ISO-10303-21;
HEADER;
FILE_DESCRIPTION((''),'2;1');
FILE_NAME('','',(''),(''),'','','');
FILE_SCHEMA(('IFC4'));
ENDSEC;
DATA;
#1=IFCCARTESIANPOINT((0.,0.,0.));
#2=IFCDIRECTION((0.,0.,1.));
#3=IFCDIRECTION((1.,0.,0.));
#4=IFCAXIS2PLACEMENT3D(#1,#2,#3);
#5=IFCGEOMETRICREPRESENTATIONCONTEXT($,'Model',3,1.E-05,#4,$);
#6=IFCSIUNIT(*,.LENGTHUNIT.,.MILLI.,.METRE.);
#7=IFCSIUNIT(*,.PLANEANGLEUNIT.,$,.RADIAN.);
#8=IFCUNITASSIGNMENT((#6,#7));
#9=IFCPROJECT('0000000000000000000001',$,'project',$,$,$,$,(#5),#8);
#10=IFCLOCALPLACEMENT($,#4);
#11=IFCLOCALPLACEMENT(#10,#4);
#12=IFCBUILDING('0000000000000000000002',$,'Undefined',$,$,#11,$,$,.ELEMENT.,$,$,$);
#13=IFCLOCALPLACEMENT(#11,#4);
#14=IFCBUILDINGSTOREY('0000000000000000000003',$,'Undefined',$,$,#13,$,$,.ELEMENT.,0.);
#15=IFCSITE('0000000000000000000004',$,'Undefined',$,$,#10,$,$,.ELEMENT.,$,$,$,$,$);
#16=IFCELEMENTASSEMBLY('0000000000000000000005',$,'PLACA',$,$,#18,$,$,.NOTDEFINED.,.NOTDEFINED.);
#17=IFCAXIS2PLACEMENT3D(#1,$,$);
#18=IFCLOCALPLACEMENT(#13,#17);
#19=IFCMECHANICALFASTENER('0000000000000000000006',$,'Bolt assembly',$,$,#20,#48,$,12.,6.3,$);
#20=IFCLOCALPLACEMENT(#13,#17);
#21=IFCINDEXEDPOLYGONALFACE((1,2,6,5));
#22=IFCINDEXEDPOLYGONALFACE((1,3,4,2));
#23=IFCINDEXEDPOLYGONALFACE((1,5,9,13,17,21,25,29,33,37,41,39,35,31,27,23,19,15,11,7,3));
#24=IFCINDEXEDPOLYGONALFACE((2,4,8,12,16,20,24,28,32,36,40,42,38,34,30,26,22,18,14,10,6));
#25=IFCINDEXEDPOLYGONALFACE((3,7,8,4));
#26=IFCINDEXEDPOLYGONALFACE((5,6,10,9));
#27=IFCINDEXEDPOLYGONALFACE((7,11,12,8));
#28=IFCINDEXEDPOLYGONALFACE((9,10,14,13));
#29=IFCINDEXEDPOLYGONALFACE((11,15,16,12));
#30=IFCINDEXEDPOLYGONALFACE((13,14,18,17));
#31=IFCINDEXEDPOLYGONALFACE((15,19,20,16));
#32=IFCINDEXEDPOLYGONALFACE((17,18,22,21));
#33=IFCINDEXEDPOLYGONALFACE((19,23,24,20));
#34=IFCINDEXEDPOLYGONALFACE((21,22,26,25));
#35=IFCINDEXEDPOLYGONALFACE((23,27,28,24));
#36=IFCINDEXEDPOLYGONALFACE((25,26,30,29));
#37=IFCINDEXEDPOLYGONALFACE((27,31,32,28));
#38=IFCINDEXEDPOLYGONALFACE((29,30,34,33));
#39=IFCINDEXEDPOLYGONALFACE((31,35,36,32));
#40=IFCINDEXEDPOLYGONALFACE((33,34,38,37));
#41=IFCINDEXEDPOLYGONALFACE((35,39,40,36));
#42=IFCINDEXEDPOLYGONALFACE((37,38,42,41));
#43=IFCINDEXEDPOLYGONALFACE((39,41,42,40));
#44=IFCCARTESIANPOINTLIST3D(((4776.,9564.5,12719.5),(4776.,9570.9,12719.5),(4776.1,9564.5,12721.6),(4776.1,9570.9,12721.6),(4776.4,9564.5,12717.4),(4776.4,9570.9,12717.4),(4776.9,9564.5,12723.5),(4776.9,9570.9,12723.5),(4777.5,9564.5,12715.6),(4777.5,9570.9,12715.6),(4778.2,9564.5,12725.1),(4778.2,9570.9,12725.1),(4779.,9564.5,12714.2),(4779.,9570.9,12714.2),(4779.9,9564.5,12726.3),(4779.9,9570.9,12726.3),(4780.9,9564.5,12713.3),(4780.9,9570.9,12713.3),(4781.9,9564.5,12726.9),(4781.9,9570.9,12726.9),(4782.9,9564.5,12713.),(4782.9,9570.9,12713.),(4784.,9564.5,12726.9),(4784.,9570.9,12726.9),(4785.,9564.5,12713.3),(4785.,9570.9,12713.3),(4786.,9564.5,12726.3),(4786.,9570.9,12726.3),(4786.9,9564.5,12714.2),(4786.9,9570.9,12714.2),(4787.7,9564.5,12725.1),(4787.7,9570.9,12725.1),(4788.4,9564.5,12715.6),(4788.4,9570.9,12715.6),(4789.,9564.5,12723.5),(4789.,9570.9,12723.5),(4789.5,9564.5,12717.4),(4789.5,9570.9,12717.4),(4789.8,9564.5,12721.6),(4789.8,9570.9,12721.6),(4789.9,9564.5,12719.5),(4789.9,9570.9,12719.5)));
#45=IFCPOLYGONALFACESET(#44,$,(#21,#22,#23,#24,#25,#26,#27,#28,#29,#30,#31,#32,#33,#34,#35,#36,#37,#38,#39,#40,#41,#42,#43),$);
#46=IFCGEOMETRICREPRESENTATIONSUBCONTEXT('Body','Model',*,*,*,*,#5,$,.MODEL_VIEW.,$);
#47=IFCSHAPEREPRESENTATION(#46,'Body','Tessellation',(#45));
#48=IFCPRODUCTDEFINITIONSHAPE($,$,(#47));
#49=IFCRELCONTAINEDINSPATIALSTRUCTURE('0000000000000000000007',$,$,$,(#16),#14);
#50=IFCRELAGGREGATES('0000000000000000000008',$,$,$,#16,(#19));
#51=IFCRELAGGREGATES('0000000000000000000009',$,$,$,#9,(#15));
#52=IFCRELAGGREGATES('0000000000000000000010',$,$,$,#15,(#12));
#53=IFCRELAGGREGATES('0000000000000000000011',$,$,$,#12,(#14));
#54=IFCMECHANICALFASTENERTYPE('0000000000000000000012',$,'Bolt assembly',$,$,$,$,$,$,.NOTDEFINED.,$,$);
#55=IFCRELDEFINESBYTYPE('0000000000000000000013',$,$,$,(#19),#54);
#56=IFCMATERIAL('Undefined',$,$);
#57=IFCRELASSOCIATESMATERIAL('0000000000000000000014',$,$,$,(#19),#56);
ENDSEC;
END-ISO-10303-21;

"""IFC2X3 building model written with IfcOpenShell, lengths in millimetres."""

from ifc_helpers import new_model, si_unit, frame, origin_with_axes, origin_2d_with_axis, place, context, subcontext, project, spatial, circle, extrude, source, transform, mapped, material, type_object, element, aggregate, save


model = new_model("IFC2X3")

# Units and contexts
model_context = context("Model", 3, precision=1e-05, world=origin_with_axes())
body_context = subcontext(model_context, "Body", "Model", "MODEL_VIEW")
ifc_project = project(units=[si_unit("LENGTHUNIT", "METRE", prefix="MILLI"), si_unit("PLANEANGLEUNIT", "RADIAN")], contexts=[model_context])

# Site, building, storey
site_placement = place(None, origin_with_axes())
site = spatial("IfcSite", under=ifc_project, at=site_placement, Name="Undefined", CompositionType="ELEMENT")
building_placement = place(site_placement, origin_with_axes())
building = spatial("IfcBuilding", under=site, at=building_placement, Name="Undefined", CompositionType="ELEMENT")
storey_placement = place(building_placement, origin_with_axes())
storey = spatial("IfcBuildingStorey", under=building, at=storey_placement, Name="Undefined", CompositionType="ELEMENT", Elevation=0.0)

# Element assembly
assembly_1_placement = place(storey_placement, origin_with_axes())
assembly_1 = element("IfcElementAssembly", 1, at=assembly_1_placement, inside=storey, Name="PLACA", AssemblyPlace="NOTDEFINED", PredefinedType="NOTDEFINED")

# Shared definitions
ifc_material_1 = material(Name="Undefined")
mechanical_fastener_type = type_object("IfcMechanicalFastenerType", Name="Bolt assembly")

# Mechanical fastener
shared_shape_1 = source(origin_with_axes(), body_context, "Body", "SweptSolid", [
    extrude(circle(Radius=7.0, at=origin_2d_with_axis()), frame((0.0, -16.4, 0.0), z_axis=(0.0, 1.0, 0.0), x_axis=(1.0, 0.0, 0.0)), (0.0, 0.0, 1.0), 6.5),
])
mechanical_fastener_1_placement = place(assembly_1_placement, frame((4782.9, 9580.9, 12720.0), z_axis=(1.0, 0.0, 0.0), x_axis=(0.0, 0.0, -1.0)))
mechanical_fastener_1 = element("IfcMechanicalFastener", 2, at=mechanical_fastener_1_placement, type_object=mechanical_fastener_type, material=ifc_material_1, Name="Bolt assembly", NominalDiameter=12.0, NominalLength=6.3, context=body_context, shape_type="MappedRepresentation", body=[
    mapped(shared_shape_1, transform((0.0, 0.0, 0.0))),
])
aggregate(assembly_1, [mechanical_fastener_1])

save(model, "model.ifc")
